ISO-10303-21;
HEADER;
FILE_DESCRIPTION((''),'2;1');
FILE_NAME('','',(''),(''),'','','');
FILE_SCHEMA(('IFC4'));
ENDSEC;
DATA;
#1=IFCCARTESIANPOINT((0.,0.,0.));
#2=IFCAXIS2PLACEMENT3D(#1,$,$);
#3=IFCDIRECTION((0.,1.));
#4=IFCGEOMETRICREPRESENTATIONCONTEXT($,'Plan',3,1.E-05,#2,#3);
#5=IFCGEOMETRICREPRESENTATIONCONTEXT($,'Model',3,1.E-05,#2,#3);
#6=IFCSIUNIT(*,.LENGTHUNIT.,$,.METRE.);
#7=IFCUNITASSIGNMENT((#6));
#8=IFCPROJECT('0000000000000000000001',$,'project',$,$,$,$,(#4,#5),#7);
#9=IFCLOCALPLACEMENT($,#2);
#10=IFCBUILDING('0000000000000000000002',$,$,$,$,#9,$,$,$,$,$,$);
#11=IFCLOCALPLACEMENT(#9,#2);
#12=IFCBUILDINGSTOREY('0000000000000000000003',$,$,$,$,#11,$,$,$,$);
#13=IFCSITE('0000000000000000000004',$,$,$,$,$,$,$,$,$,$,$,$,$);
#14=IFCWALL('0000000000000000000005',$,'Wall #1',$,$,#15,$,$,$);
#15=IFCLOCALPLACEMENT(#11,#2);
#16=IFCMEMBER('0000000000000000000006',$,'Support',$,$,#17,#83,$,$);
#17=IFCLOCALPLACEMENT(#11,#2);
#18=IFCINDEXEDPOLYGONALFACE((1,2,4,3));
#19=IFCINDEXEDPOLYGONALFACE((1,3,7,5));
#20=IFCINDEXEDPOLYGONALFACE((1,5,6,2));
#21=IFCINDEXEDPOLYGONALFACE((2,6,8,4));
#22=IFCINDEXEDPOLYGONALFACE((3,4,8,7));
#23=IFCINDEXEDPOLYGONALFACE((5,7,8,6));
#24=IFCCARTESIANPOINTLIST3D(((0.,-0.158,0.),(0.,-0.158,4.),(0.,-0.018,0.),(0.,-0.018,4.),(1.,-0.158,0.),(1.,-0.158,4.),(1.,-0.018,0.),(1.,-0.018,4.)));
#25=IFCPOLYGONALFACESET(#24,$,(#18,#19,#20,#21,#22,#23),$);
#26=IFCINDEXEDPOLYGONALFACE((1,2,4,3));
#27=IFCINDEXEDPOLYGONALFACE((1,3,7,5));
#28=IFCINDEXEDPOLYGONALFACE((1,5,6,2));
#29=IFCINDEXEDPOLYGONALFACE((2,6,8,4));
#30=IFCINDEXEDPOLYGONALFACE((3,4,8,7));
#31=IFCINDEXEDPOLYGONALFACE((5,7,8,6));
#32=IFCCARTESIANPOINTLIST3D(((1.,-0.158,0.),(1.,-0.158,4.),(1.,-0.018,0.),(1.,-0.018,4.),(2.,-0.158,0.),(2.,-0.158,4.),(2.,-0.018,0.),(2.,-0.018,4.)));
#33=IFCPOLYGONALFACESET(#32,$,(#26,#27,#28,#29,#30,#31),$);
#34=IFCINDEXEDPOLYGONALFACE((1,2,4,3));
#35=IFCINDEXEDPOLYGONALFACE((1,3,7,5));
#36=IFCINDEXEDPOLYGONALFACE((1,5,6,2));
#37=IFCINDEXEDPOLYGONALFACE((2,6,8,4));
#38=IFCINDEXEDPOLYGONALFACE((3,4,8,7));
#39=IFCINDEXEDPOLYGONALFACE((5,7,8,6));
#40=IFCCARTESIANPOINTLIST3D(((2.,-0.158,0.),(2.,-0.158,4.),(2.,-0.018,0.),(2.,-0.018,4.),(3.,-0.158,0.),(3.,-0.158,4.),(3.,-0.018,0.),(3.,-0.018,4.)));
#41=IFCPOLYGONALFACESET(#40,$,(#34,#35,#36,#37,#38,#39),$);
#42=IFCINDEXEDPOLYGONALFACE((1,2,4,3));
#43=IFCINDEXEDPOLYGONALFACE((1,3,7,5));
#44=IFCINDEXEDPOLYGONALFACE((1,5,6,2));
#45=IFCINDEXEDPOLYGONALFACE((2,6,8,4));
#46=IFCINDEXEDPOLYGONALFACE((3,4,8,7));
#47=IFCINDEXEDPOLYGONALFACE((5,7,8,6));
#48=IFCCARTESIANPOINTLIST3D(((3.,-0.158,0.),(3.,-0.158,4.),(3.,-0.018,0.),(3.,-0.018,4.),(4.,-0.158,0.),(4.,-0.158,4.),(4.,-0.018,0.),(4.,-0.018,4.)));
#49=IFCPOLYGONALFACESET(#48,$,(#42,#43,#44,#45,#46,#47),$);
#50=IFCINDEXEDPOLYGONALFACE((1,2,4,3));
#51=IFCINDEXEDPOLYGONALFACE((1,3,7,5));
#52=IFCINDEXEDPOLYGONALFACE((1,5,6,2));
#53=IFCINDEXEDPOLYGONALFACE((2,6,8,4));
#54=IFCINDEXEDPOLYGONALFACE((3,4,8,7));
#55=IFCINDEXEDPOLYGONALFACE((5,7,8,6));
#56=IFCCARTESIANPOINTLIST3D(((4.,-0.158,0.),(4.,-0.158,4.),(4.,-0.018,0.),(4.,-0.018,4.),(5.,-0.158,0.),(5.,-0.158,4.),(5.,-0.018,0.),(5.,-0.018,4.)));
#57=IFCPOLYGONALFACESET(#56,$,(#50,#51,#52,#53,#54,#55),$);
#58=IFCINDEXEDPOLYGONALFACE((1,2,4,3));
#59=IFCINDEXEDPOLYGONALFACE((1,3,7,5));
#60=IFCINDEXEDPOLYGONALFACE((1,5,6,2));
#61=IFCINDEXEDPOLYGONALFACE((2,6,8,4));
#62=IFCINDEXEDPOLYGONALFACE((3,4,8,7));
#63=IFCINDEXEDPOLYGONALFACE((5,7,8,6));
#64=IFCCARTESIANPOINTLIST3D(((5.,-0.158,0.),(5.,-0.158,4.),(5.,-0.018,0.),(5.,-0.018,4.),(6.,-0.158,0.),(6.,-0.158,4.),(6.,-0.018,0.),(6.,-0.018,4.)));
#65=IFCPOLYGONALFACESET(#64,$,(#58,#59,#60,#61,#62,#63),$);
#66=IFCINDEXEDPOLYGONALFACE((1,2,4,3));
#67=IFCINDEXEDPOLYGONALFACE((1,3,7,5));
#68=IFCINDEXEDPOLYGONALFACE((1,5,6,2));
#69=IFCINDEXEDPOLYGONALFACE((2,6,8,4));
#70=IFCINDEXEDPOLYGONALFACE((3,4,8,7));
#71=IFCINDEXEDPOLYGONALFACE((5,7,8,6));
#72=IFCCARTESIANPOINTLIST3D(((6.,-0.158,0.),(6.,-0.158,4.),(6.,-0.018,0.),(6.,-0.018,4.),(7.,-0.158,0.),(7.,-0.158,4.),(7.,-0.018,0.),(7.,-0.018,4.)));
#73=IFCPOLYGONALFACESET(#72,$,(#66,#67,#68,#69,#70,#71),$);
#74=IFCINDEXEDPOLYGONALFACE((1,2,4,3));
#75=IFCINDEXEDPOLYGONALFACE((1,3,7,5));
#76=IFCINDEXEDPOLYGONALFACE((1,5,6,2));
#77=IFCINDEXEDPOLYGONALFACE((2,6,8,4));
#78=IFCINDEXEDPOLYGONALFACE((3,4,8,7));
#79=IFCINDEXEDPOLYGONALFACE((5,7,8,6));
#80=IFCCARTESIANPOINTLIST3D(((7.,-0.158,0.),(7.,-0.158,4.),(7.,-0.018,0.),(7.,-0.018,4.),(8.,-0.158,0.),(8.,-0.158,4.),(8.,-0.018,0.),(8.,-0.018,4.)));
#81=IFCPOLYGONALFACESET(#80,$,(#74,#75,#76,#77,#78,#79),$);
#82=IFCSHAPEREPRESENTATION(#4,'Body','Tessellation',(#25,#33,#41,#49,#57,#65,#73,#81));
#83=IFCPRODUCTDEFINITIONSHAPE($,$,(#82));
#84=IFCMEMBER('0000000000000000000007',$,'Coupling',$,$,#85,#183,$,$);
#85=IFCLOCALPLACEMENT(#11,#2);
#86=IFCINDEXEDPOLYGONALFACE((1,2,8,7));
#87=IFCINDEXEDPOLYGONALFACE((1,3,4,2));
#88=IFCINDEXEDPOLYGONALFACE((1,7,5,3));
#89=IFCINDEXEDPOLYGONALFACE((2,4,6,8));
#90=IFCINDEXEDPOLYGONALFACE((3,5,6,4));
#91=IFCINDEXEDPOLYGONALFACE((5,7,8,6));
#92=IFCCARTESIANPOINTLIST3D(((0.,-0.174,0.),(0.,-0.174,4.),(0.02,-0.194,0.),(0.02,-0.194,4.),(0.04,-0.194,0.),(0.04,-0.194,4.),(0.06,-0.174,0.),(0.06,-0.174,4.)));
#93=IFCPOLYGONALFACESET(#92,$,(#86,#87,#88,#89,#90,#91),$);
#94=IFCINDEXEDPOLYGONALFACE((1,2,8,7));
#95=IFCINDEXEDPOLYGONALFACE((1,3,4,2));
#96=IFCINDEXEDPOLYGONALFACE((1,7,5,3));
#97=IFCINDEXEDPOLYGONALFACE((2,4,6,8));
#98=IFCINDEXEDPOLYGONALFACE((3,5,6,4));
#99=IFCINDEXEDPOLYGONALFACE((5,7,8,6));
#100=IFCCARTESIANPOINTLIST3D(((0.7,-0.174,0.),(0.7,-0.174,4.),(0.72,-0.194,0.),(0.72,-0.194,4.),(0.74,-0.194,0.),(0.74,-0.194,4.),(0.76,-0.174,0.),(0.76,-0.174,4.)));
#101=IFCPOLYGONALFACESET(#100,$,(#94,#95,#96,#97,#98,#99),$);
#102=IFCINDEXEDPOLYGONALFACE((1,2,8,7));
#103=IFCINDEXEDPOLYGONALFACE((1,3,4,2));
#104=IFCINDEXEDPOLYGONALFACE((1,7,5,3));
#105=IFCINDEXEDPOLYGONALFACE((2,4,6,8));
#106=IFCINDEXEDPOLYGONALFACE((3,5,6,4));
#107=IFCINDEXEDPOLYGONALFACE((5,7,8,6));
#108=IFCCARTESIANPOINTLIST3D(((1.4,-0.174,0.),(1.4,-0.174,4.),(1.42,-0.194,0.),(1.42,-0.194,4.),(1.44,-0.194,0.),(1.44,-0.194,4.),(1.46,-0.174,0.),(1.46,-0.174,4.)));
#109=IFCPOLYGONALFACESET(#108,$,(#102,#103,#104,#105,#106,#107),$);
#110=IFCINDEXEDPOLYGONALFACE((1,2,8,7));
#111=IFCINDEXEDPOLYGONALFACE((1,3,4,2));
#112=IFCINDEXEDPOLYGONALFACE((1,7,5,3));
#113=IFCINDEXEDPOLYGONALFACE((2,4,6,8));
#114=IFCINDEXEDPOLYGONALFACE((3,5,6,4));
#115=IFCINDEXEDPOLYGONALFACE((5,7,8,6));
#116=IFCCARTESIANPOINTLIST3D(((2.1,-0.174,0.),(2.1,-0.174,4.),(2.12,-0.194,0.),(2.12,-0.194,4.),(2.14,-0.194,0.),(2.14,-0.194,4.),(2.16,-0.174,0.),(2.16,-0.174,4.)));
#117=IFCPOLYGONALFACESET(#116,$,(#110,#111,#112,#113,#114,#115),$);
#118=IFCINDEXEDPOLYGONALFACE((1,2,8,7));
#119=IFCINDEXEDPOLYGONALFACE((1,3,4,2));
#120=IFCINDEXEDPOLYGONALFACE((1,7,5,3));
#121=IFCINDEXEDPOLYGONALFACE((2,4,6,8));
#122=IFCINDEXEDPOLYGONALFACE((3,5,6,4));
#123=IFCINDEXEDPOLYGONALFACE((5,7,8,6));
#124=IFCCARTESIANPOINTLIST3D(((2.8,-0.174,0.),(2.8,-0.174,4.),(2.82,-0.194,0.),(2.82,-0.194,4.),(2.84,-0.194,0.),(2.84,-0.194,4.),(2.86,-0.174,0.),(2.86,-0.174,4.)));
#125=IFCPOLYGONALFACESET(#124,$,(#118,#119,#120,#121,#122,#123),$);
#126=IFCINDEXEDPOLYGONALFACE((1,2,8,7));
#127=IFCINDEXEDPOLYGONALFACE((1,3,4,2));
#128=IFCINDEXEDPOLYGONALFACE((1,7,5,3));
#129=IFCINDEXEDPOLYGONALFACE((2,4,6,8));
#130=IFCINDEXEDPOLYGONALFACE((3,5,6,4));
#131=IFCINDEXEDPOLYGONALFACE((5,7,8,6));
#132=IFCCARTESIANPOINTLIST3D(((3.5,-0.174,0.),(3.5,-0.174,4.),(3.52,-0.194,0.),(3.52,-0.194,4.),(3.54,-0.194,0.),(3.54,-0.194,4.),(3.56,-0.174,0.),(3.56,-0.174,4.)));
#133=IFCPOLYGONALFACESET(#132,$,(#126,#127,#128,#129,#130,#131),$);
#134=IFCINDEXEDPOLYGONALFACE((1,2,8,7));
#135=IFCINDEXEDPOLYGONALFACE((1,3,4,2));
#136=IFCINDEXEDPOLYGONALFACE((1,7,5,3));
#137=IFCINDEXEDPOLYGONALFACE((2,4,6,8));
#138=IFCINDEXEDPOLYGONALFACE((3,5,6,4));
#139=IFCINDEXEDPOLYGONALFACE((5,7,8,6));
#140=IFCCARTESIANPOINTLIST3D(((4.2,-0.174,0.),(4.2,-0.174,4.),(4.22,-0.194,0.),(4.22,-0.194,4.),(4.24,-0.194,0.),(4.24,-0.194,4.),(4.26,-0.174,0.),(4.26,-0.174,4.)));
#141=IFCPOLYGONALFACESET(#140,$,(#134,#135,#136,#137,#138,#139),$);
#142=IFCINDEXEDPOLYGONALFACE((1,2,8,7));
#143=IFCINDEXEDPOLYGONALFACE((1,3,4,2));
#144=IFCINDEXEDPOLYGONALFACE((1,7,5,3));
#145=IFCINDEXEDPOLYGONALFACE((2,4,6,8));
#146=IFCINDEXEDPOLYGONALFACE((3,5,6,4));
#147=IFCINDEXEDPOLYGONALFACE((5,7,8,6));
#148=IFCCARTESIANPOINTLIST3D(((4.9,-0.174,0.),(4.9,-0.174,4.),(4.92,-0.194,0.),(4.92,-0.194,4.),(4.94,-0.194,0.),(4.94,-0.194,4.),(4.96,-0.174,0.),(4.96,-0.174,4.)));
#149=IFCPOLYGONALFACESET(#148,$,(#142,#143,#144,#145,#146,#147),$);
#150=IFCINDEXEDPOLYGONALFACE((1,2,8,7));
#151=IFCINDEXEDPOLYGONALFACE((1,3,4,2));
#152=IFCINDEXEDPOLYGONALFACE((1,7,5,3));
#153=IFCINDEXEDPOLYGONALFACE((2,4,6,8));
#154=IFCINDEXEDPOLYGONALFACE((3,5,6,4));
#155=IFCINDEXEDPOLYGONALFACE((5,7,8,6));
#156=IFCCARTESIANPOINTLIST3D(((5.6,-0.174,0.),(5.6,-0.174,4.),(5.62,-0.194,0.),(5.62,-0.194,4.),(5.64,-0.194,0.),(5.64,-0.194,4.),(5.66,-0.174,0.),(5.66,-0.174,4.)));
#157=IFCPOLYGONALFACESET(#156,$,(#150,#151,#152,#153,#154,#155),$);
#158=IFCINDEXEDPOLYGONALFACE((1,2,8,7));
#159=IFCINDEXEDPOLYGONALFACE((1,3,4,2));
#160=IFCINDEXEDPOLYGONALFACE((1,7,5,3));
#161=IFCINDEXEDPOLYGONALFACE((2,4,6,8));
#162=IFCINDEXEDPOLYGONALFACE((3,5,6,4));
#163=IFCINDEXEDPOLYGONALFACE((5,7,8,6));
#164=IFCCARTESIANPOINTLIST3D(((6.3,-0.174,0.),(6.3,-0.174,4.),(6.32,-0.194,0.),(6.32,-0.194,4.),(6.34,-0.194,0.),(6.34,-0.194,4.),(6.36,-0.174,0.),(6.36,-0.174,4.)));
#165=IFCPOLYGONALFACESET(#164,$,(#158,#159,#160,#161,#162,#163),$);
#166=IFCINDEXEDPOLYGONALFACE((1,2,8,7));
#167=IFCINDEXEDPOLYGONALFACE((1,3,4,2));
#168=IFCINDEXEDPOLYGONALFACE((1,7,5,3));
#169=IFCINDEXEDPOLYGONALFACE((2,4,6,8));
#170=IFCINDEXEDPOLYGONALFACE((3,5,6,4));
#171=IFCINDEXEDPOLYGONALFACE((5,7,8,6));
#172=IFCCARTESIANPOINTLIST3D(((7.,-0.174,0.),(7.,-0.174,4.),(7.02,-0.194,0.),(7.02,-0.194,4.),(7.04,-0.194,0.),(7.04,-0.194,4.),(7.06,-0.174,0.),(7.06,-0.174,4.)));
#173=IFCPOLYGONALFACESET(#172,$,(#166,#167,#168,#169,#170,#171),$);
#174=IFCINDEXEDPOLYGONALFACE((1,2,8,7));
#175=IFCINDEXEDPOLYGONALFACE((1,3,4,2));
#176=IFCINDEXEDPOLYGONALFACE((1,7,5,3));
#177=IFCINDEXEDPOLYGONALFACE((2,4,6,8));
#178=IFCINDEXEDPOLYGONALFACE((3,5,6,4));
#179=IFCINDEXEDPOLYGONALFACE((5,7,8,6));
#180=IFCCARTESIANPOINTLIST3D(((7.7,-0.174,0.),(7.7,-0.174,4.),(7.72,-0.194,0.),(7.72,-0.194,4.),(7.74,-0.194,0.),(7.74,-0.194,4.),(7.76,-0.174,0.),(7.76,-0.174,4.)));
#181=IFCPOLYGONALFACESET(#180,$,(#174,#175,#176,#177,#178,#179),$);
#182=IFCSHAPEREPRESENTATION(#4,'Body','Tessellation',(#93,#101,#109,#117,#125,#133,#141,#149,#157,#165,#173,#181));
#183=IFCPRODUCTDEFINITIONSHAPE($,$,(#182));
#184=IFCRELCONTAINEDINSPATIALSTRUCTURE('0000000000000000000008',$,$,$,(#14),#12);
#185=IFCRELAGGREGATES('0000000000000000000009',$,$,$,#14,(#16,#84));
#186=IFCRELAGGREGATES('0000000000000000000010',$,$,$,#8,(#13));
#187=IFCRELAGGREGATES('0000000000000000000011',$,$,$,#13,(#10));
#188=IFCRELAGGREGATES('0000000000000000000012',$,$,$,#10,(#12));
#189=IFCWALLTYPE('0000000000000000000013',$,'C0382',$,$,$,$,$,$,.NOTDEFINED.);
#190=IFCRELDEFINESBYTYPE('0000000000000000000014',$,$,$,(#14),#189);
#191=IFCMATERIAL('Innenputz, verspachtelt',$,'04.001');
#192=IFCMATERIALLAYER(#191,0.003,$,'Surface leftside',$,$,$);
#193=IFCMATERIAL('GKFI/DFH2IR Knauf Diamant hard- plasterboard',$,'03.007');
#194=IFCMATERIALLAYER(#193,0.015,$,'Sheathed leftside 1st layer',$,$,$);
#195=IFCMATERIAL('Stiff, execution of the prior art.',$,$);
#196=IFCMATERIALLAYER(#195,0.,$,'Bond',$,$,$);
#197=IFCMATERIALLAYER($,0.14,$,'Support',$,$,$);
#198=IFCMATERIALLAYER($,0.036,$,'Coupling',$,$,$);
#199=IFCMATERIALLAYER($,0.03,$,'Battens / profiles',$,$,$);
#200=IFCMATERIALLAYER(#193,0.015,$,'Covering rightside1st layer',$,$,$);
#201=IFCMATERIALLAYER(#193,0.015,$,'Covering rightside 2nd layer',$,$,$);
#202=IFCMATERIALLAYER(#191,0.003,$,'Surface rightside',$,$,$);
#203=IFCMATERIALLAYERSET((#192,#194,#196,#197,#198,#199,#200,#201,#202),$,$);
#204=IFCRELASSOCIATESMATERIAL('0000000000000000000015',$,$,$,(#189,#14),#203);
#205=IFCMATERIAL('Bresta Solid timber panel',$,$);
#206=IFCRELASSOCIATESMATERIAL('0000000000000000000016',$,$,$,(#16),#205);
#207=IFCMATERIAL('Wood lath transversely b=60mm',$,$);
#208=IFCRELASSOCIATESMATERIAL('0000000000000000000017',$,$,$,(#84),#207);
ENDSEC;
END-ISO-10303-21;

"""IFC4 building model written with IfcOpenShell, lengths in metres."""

from ifc_helpers import new_model, si_unit, direction, frame, frame_2d, origin, place, context, project, spatial, polyline, rectangle, outline, extrude, material, layer, layer_set, type_object, element, aggregate, save


model = new_model("IFC4")

# Units and contexts
plan_context = context("Plan", 3, precision=1e-05, world=origin(), true_north=direction((0.0, 1.0)))
model_context = context("Model", 3, precision=1e-05, world=origin(), true_north=direction((0.0, 1.0)))
ifc_project = project(units=[si_unit("LENGTHUNIT", "METRE")], contexts=[plan_context, model_context])

# Site, building, storey
site = spatial("IfcSite", under=ifc_project)
building_placement = place(None, origin())
building = spatial("IfcBuilding", under=site, at=building_placement)
storey_placement = place(building_placement, origin())
storey = spatial("IfcBuildingStorey", under=building, at=storey_placement)

# Wall, members
ifc_material_1 = material(Name="Innenputz, verspachtelt", Category="04.001")
ifc_layer_1 = layer(ifc_material_1, 0.003, Name="Surface leftside")
ifc_material_2 = material(Name="GKFI/DFH2IR Knauf Diamant hard- plasterboard", Category="03.007")
ifc_layer_2 = layer(ifc_material_2, 0.015, Name="Sheathed leftside 1st layer")
ifc_material_3 = material(Name="Stiff, execution of the prior art.")
ifc_layer_3 = layer(ifc_material_3, 0.0, Name="Bond")
ifc_layer_4 = layer(None, 0.14, Name="Support")
ifc_layer_5 = layer(None, 0.036, Name="Coupling")
ifc_layer_6 = layer(None, 0.03, Name="Battens / profiles")
ifc_layer_7 = layer(ifc_material_2, 0.015, Name="Covering rightside1st layer")
ifc_layer_8 = layer(ifc_material_2, 0.015, Name="Covering rightside 2nd layer")
ifc_layer_9 = layer(ifc_material_1, 0.003, Name="Surface rightside")
ifc_layer_set = layer_set([ifc_layer_1, ifc_layer_2, ifc_layer_3, ifc_layer_4, ifc_layer_5, ifc_layer_6, ifc_layer_7, ifc_layer_8, ifc_layer_9])
wall_type = type_object("IfcWallType", Name="C0382", PredefinedType="NOTDEFINED", material=ifc_layer_set)
wall_placement = place(None, frame((0.0, 0.0, 0.0), z_axis=(0.0, -1.0, 0.0), x_axis=(1.0, 0.0, 0.0)))
wall = element("IfcWall", 1, at=wall_placement, inside=storey, type_object=wall_type, material=ifc_layer_set, Name="Wall #1")
ifc_material_4 = material(Name="Bresta Solid timber panel")
member_1_placement = place(wall_placement, origin())
member_1 = element("IfcMember", 2, at=member_1_placement, material=ifc_material_4, Name="Support", context=plan_context, shape_type="SweptSolid", body=[
    extrude(rectangle(XDim=1.0, YDim=0.14, at=frame_2d((0.5, 0.07), x_axis=(1.0, 0.0))), frame((0.0, 4.0, 0.018), z_axis=(0.0, -1.0, 0.0), x_axis=(1.0, 0.0, 0.0)), (0.0, 0.0, 1.0), 4.0),
    extrude(rectangle(XDim=1.0, YDim=0.14, at=frame_2d((0.5, 0.07), x_axis=(1.0, 0.0))), frame((1.0, 4.0, 0.018), z_axis=(0.0, -1.0, 0.0), x_axis=(1.0, 0.0, 0.0)), (0.0, 0.0, 1.0), 4.0),
    extrude(rectangle(XDim=1.0, YDim=0.14, at=frame_2d((0.5, 0.07), x_axis=(1.0, 0.0))), frame((2.0, 4.0, 0.018), z_axis=(0.0, -1.0, 0.0), x_axis=(1.0, 0.0, 0.0)), (0.0, 0.0, 1.0), 4.0),
    extrude(rectangle(XDim=1.0, YDim=0.14, at=frame_2d((0.5, 0.07), x_axis=(1.0, 0.0))), frame((3.0, 4.0, 0.018), z_axis=(0.0, -1.0, 0.0), x_axis=(1.0, 0.0, 0.0)), (0.0, 0.0, 1.0), 4.0),
    extrude(rectangle(XDim=1.0, YDim=0.14, at=frame_2d((0.5, 0.07), x_axis=(1.0, 0.0))), frame((4.0, 4.0, 0.018), z_axis=(0.0, -1.0, 0.0), x_axis=(1.0, 0.0, 0.0)), (0.0, 0.0, 1.0), 4.0),
    extrude(rectangle(XDim=1.0, YDim=0.14, at=frame_2d((0.5, 0.07), x_axis=(1.0, 0.0))), frame((5.0, 4.0, 0.018), z_axis=(0.0, -1.0, 0.0), x_axis=(1.0, 0.0, 0.0)), (0.0, 0.0, 1.0), 4.0),
    extrude(rectangle(XDim=1.0, YDim=0.14, at=frame_2d((0.5, 0.07), x_axis=(1.0, 0.0))), frame((6.0, 4.0, 0.018), z_axis=(0.0, -1.0, 0.0), x_axis=(1.0, 0.0, 0.0)), (0.0, 0.0, 1.0), 4.0),
    extrude(rectangle(XDim=1.0, YDim=0.14, at=frame_2d((0.5, 0.07), x_axis=(1.0, 0.0))), frame((7.0, 4.0, 0.018), z_axis=(0.0, -1.0, 0.0), x_axis=(1.0, 0.0, 0.0)), (0.0, 0.0, 1.0), 4.0),
])
ifc_material_5 = material(Name="Wood lath transversely b=60mm")
member_2_placement = place(wall_placement, origin())
member_2 = element("IfcMember", 3, at=member_2_placement, material=ifc_material_5, Name="Coupling", context=plan_context, shape_type="SweptSolid", body=[
    extrude(outline(polyline([(0.0, 0.0), (0.06, 0.0), (0.04, 0.02), (0.02, 0.02), (0.0, 0.0)])), frame((0.0, 4.0, 0.174), z_axis=(0.0, -1.0, 0.0), x_axis=(1.0, 0.0, 0.0)), (0.0, 0.0, 1.0), 4.0),
    extrude(outline(polyline([(0.0, 0.0), (0.06, 0.0), (0.04, 0.02), (0.02, 0.02), (0.0, 0.0)])), frame((0.7, 4.0, 0.174), z_axis=(0.0, -1.0, 0.0), x_axis=(1.0, 0.0, 0.0)), (0.0, 0.0, 1.0), 4.0),
    extrude(outline(polyline([(0.0, 0.0), (0.06, 0.0), (0.04, 0.02), (0.02, 0.02), (0.0, 0.0)])), frame((1.4, 4.0, 0.174), z_axis=(0.0, -1.0, 0.0), x_axis=(1.0, 0.0, 0.0)), (0.0, 0.0, 1.0), 4.0),
    extrude(outline(polyline([(0.0, 0.0), (0.06, 0.0), (0.04, 0.02), (0.02, 0.02), (0.0, 0.0)])), frame((2.1, 4.0, 0.174), z_axis=(0.0, -1.0, 0.0), x_axis=(1.0, 0.0, 0.0)), (0.0, 0.0, 1.0), 4.0),
    extrude(outline(polyline([(0.0, 0.0), (0.06, 0.0), (0.04, 0.02), (0.02, 0.02), (0.0, 0.0)])), frame((2.8, 4.0, 0.174), z_axis=(0.0, -1.0, 0.0), x_axis=(1.0, 0.0, 0.0)), (0.0, 0.0, 1.0), 4.0),
    extrude(outline(polyline([(0.0, 0.0), (0.06, 0.0), (0.04, 0.02), (0.02, 0.02), (0.0, 0.0)])), frame((3.5, 4.0, 0.174), z_axis=(0.0, -1.0, 0.0), x_axis=(1.0, 0.0, 0.0)), (0.0, 0.0, 1.0), 4.0),
    extrude(outline(polyline([(0.0, 0.0), (0.06, 0.0), (0.04, 0.02), (0.02, 0.02), (0.0, 0.0)])), frame((4.2, 4.0, 0.174), z_axis=(0.0, -1.0, 0.0), x_axis=(1.0, 0.0, 0.0)), (0.0, 0.0, 1.0), 4.0),
    extrude(outline(polyline([(0.0, 0.0), (0.06, 0.0), (0.04, 0.02), (0.02, 0.02), (0.0, 0.0)])), frame((4.9, 4.0, 0.174), z_axis=(0.0, -1.0, 0.0), x_axis=(1.0, 0.0, 0.0)), (0.0, 0.0, 1.0), 4.0),
    extrude(outline(polyline([(0.0, 0.0), (0.06, 0.0), (0.04, 0.02), (0.02, 0.02), (0.0, 0.0)])), frame((5.6, 4.0, 0.174), z_axis=(0.0, -1.0, 0.0), x_axis=(1.0, 0.0, 0.0)), (0.0, 0.0, 1.0), 4.0),
    extrude(outline(polyline([(0.0, 0.0), (0.06, 0.0), (0.04, 0.02), (0.02, 0.02), (0.0, 0.0)])), frame((6.3, 4.0, 0.174), z_axis=(0.0, -1.0, 0.0), x_axis=(1.0, 0.0, 0.0)), (0.0, 0.0, 1.0), 4.0),
    extrude(outline(polyline([(0.0, 0.0), (0.06, 0.0), (0.04, 0.02), (0.02, 0.02), (0.0, 0.0)])), frame((7.0, 4.0, 0.174), z_axis=(0.0, -1.0, 0.0), x_axis=(1.0, 0.0, 0.0)), (0.0, 0.0, 1.0), 4.0),
    extrude(outline(polyline([(0.0, 0.0), (0.06, 0.0), (0.04, 0.02), (0.02, 0.02), (0.0, 0.0)])), frame((7.7, 4.0, 0.174), z_axis=(0.0, -1.0, 0.0), x_axis=(1.0, 0.0, 0.0)), (0.0, 0.0, 1.0), 4.0),
])
aggregate(wall, [member_1, member_2])

save(model, "model.ifc")
